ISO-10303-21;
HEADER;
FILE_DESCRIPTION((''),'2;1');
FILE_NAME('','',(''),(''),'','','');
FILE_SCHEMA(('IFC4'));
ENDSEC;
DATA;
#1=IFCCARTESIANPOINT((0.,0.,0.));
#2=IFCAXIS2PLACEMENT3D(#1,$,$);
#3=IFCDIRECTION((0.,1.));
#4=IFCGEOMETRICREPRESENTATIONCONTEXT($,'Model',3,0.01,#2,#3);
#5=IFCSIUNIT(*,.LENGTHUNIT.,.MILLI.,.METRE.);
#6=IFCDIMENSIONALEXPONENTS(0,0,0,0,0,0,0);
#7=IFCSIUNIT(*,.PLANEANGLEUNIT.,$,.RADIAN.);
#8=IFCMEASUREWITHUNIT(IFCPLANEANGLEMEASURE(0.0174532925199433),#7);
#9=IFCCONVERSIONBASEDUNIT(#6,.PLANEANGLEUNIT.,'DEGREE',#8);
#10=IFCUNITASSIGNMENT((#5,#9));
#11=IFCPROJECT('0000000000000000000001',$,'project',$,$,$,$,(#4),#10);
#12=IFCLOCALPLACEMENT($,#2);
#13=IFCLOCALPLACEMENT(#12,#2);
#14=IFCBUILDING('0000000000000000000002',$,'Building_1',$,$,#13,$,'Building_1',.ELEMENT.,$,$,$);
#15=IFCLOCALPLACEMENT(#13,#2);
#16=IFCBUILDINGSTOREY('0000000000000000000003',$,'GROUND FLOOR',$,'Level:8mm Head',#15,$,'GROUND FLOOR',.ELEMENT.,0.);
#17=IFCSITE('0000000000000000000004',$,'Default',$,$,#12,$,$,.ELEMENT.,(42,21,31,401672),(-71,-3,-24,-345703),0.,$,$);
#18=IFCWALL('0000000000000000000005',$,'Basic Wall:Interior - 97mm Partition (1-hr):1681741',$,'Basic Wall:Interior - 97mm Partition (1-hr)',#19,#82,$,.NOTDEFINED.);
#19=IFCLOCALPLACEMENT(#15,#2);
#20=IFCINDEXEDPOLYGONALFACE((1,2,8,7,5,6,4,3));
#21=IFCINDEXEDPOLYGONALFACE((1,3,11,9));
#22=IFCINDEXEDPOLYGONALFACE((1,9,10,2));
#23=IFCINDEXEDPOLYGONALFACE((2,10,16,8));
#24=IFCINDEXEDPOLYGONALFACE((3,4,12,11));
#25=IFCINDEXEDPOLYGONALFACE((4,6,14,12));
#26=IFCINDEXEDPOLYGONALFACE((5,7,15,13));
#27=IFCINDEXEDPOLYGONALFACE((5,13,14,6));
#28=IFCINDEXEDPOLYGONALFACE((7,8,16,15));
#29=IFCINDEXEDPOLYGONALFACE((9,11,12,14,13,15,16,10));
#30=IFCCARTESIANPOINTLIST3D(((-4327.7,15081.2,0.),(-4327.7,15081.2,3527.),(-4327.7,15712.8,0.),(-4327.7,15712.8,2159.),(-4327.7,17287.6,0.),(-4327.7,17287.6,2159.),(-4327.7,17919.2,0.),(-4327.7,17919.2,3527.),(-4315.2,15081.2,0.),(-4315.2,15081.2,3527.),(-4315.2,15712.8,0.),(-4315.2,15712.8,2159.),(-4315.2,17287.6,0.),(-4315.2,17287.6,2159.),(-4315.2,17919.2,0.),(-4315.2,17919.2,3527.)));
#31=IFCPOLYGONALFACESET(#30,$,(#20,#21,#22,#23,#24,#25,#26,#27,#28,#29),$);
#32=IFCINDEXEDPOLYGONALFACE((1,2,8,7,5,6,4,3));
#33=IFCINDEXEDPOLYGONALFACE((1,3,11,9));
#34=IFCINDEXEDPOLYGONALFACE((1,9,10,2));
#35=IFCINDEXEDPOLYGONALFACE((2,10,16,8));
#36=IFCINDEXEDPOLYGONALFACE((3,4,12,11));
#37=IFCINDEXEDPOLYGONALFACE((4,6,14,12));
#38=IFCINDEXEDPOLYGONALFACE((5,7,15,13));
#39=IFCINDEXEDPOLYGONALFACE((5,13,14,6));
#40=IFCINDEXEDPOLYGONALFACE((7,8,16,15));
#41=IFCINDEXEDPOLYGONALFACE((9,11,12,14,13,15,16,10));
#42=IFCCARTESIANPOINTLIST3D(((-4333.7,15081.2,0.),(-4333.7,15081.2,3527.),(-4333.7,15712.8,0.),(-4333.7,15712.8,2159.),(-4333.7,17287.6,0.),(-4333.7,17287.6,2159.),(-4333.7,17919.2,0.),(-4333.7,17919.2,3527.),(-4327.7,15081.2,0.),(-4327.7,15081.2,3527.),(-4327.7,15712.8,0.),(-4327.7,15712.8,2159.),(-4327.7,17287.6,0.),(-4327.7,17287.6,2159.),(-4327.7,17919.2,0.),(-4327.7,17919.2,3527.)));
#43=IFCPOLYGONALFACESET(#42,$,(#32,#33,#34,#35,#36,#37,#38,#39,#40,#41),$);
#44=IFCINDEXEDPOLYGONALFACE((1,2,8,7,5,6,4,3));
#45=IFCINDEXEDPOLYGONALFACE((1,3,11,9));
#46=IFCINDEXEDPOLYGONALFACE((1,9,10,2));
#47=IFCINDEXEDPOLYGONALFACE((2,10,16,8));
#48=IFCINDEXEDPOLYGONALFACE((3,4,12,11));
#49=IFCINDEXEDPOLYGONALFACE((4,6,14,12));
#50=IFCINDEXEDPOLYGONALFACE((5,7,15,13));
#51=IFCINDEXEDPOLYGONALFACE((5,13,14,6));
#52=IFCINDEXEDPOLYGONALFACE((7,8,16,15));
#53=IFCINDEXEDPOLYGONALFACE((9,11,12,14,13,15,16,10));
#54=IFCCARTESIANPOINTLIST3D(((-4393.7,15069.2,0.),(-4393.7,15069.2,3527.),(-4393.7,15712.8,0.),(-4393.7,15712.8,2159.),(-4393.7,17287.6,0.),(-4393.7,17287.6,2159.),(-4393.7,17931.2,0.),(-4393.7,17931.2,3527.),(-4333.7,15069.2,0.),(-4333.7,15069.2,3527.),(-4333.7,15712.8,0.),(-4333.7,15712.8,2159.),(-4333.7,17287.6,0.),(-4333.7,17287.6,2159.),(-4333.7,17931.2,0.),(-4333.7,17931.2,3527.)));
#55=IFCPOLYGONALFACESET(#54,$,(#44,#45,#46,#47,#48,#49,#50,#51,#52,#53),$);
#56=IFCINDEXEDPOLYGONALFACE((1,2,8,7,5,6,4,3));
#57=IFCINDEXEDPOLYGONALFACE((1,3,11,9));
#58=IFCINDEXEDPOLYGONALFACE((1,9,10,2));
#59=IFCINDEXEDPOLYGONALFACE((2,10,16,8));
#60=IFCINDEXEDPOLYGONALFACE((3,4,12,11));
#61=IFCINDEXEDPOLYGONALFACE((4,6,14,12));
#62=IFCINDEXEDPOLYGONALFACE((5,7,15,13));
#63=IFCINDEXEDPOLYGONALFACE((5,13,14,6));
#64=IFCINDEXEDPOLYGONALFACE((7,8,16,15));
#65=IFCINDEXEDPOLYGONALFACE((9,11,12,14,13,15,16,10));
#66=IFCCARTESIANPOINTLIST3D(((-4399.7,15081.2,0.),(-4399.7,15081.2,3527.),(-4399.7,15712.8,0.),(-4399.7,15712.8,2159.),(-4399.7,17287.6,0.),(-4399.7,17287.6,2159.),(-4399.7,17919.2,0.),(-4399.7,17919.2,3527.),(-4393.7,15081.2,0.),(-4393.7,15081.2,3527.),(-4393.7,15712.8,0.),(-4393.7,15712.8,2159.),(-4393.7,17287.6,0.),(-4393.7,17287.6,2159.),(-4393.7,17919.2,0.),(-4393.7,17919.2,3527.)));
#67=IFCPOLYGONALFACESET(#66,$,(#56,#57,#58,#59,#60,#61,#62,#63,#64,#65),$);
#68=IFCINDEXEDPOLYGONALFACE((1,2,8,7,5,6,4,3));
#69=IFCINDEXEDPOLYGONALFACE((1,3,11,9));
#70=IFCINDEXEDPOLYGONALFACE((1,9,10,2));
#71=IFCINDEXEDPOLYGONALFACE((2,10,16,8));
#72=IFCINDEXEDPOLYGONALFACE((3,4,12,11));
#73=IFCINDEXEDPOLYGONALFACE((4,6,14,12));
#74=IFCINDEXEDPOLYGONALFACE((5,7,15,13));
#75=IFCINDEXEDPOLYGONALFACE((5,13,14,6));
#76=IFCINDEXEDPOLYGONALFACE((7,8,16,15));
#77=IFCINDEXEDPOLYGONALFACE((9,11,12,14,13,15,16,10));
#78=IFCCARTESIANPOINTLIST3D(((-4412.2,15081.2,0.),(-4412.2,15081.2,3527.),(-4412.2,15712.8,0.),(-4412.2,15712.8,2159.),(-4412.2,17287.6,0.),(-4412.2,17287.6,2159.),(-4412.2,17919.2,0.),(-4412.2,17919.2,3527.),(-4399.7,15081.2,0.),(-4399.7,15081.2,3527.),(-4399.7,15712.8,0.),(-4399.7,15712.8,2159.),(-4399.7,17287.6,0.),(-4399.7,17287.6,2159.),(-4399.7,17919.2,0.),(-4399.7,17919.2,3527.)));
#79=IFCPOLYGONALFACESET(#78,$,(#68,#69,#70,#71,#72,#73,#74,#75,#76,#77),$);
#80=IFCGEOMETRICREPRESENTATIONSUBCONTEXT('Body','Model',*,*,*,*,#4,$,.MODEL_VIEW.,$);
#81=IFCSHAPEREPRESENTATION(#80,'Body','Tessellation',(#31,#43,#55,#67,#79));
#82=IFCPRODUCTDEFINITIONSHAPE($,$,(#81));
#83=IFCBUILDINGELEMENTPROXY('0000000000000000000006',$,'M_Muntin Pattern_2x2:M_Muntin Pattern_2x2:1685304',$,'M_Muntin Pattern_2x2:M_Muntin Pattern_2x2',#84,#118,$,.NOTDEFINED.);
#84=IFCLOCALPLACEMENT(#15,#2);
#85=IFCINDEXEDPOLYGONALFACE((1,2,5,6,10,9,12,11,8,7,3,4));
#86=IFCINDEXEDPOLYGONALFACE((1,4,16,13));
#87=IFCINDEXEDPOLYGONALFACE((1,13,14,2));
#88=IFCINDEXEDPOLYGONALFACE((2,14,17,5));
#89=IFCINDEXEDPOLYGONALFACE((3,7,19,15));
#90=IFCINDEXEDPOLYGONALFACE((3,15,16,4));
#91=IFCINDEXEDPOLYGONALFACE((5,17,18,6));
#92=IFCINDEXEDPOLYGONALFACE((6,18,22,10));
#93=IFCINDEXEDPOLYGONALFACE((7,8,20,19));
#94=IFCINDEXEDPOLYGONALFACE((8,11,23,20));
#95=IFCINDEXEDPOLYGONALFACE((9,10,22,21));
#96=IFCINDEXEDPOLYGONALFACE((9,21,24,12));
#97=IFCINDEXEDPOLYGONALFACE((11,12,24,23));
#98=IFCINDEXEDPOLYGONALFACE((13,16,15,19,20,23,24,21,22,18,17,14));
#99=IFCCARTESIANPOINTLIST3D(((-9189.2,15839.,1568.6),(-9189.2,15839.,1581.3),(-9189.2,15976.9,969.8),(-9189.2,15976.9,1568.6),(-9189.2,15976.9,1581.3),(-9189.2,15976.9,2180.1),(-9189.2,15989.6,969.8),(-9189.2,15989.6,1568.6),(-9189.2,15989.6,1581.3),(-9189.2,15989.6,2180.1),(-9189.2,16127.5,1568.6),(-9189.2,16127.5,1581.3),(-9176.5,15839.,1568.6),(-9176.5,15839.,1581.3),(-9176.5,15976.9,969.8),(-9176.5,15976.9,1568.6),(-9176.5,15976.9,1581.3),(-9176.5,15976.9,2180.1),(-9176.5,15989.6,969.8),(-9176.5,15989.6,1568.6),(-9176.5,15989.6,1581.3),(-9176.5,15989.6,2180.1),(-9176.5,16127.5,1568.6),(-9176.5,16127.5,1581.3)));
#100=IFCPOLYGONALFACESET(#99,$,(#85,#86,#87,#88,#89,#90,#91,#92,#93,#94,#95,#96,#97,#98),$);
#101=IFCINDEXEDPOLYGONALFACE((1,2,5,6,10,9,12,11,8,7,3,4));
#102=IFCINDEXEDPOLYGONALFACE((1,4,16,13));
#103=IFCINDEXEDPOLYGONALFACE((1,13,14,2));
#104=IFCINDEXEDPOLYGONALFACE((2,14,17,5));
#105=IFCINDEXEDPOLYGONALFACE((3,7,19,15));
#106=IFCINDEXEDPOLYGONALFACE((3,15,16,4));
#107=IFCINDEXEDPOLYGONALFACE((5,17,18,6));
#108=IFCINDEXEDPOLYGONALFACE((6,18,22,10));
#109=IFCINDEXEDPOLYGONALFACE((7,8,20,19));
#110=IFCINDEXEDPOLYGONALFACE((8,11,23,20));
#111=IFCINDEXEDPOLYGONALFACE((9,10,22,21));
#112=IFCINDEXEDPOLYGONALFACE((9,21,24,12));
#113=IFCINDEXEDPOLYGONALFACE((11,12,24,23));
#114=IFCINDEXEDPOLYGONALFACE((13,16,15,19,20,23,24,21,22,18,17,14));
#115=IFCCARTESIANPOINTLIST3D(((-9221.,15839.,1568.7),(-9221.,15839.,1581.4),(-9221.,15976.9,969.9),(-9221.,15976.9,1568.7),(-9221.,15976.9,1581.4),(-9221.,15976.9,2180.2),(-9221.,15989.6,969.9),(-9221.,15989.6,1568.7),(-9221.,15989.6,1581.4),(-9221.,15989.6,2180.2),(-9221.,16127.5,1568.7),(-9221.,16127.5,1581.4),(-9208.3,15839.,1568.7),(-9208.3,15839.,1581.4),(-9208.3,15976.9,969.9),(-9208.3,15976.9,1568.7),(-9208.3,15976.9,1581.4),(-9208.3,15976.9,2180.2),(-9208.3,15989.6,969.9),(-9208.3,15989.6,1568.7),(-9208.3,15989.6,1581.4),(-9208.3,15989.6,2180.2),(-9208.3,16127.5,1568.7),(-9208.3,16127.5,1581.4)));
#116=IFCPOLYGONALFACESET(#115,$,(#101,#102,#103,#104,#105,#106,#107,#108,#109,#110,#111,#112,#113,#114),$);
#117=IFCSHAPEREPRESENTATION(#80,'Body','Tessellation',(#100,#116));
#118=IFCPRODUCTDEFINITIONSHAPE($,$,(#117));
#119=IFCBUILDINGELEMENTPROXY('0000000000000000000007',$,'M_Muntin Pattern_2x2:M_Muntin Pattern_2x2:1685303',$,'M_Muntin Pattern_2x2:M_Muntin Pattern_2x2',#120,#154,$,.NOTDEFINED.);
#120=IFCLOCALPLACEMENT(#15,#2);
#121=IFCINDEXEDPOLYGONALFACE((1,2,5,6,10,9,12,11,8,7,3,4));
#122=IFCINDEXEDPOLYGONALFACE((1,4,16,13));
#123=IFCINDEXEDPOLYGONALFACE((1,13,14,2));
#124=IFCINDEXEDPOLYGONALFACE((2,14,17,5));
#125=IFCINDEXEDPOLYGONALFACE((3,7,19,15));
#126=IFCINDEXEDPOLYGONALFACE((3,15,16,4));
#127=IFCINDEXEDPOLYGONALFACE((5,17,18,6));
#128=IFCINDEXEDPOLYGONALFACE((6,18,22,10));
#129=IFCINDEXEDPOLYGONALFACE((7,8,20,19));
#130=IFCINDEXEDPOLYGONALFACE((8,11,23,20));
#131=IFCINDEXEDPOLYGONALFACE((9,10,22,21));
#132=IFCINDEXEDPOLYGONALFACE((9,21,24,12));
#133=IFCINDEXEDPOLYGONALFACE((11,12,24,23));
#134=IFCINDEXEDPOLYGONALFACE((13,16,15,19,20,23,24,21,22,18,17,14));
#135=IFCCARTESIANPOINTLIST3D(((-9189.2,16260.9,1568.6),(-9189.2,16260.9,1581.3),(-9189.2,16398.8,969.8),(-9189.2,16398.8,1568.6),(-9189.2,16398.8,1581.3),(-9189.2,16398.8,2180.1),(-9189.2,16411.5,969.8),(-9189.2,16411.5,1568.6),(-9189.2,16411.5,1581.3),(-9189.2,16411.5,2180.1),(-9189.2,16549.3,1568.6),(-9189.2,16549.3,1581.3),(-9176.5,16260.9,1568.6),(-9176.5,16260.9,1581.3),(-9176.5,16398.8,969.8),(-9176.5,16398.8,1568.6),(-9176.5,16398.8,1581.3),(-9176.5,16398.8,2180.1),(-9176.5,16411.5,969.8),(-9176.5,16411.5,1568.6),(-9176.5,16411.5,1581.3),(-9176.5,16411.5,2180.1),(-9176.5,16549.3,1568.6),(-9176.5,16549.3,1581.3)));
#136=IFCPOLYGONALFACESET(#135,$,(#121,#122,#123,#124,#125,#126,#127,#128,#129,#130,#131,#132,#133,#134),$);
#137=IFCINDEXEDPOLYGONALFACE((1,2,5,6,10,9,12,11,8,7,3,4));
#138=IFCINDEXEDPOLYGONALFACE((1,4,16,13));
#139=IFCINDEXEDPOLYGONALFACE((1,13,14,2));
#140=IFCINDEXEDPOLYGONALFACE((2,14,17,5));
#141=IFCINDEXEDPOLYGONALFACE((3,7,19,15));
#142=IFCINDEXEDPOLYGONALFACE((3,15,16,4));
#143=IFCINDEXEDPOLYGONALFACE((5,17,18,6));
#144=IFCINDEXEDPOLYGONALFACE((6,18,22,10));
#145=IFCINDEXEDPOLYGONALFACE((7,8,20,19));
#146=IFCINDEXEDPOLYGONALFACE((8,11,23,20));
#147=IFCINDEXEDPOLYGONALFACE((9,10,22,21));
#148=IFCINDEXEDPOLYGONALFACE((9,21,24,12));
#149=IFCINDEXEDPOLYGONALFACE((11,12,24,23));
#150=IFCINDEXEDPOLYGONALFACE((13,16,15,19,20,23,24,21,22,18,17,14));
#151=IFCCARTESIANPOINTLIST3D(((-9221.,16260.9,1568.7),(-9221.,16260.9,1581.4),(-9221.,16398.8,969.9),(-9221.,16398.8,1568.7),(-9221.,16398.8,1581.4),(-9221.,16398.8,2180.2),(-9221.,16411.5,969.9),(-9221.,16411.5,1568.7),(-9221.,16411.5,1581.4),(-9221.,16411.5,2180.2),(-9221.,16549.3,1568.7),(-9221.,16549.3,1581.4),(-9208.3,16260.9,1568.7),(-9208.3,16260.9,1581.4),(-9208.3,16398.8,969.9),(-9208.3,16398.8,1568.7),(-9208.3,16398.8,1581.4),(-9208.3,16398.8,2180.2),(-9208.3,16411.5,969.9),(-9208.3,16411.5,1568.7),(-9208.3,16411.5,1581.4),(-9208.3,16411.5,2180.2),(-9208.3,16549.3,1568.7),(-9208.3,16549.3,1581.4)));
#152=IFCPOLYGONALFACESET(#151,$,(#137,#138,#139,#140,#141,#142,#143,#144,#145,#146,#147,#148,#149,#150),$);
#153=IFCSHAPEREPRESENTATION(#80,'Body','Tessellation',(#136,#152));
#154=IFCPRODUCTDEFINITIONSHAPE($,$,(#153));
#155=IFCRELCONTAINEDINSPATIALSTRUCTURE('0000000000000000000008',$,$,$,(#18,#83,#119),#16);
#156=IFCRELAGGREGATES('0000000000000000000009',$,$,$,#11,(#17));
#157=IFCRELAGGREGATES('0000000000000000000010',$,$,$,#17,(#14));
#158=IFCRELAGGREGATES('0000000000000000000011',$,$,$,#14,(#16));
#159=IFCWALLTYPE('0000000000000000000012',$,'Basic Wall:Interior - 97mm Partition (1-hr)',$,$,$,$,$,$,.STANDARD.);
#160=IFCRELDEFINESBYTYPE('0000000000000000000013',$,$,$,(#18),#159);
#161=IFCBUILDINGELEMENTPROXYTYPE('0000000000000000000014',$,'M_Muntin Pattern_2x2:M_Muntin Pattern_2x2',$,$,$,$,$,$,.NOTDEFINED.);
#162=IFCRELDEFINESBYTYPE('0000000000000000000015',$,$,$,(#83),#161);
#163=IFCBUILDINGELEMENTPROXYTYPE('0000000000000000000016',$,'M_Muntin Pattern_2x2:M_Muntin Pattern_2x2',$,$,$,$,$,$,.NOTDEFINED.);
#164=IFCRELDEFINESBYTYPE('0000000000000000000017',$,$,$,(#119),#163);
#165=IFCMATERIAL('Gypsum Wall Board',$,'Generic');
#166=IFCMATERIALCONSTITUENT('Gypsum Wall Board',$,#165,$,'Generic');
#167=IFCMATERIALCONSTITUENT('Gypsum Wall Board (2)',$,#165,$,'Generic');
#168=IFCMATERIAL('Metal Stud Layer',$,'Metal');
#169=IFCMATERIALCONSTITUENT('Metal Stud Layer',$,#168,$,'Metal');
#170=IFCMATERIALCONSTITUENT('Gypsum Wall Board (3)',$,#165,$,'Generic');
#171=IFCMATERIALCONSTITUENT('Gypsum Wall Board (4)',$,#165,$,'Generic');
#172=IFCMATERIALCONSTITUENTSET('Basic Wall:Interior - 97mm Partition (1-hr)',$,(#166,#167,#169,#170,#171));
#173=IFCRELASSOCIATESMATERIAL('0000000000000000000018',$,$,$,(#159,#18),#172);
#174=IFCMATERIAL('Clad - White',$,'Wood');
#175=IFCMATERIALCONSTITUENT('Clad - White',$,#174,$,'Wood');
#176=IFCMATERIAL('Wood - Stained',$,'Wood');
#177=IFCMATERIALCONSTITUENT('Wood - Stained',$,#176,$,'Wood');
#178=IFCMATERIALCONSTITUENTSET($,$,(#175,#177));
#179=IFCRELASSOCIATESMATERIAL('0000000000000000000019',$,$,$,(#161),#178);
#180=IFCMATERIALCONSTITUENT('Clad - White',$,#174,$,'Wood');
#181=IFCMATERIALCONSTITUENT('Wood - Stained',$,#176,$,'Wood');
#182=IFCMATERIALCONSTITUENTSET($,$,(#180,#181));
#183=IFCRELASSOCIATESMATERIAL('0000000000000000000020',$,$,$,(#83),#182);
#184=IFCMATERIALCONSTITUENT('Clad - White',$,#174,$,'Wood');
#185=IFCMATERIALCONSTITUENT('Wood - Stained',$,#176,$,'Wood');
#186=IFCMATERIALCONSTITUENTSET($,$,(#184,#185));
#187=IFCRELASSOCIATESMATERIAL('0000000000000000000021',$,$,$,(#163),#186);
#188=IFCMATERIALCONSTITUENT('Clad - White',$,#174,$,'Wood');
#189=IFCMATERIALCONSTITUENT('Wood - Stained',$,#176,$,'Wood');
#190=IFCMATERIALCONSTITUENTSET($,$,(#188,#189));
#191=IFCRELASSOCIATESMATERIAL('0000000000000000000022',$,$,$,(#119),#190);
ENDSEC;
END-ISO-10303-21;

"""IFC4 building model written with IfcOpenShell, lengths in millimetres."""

from ifc_helpers import new_model, entity, si_unit, converted_unit, direction, frame, origin, place, context, subcontext, project, spatial, indexed_curve, outline, extrude, source, transform, mapped, material, constituent, constituent_set, type_object, type_shapes, element, save


model = new_model("IFC4")

# Units and contexts
model_context = context("Model", 3, precision=0.01, world=origin(), true_north=direction((0.0, 1.0)))
body_context = subcontext(model_context, "Body", "Model", "MODEL_VIEW")
ifc_project = project(units=[si_unit("LENGTHUNIT", "METRE", prefix="MILLI"), converted_unit("PLANEANGLEUNIT", "DEGREE", entity("IfcPlaneAngleMeasure", 0.0174532925199433), si_unit("PLANEANGLEUNIT", "RADIAN"), dimensions=[0, 0, 0, 0, 0, 0, 0])], contexts=[model_context])

# Site, building, storey
site_placement = place(None, origin())
site = spatial("IfcSite", under=ifc_project, at=site_placement, Name="Default", CompositionType="ELEMENT", RefLatitude=(42, 21, 31, 401672), RefLongitude=(-71, -3, -24, -345703), RefElevation=0.0)
building_placement = place(site_placement, origin())
building = spatial("IfcBuilding", under=site, at=building_placement, Name="Building_1", LongName="Building_1", CompositionType="ELEMENT")
storey_placement = place(building_placement, origin())
storey = spatial("IfcBuildingStorey", under=building, at=storey_placement, Name="GROUND FLOOR", ObjectType="Level:8mm Head", LongName="GROUND FLOOR", CompositionType="ELEMENT", Elevation=0.0)

# Shared definitions
ifc_material_1 = material(Name="Wood - Stained", Category="Wood")

# Wall, opening
ifc_material_2 = material(Name="Gypsum Wall Board", Category="Generic")
ifc_constituent_1 = constituent(ifc_material_2, Name="Gypsum Wall Board", Category="Generic")
ifc_constituent_2 = constituent(ifc_material_2, Name="Gypsum Wall Board (2)", Category="Generic")
ifc_material_3 = material(Name="Metal Stud Layer", Category="Metal")
ifc_constituent_3 = constituent(ifc_material_3, Name="Metal Stud Layer", Category="Metal")
ifc_constituent_4 = constituent(ifc_material_2, Name="Gypsum Wall Board (3)", Category="Generic")
ifc_constituent_5 = constituent(ifc_material_2, Name="Gypsum Wall Board (4)", Category="Generic")
ifc_constituent_set_1 = constituent_set(constituents=[ifc_constituent_1, ifc_constituent_2, ifc_constituent_3, ifc_constituent_4, ifc_constituent_5], Name="Basic Wall:Interior - 97mm Partition (1-hr)")
wall_type_1 = type_object("IfcWallType", Name="Basic Wall:Interior - 97mm Partition (1-hr)", PredefinedType="STANDARD", material=ifc_constituent_set_1)
wall_1_placement = place(storey_placement, frame((-4363.7, 15081.2, 0.0), z_axis=(0.0, 0.0, 1.0), x_axis=(0.0, 1.0, 0.0)))
wall_1 = element("IfcWall", 1, at=wall_1_placement, inside=storey, type_object=wall_type_1, material=ifc_constituent_set_1, Name="Basic Wall:Interior - 97mm Partition (1-hr):1681741", ObjectType="Basic Wall:Interior - 97mm Partition (1-hr)", PredefinedType="NOTDEFINED", context=body_context, shape_type="SweptSolid", body=[
    extrude(outline(indexed_curve([(-1421.5, -1419.0), (2105.5, -1419.0), (2105.5, 1419.0), (-1421.5, 1419.0), (-1421.5, 787.4), (737.5, 787.4), (737.5, -787.4), (-1421.5, -787.4), (-1421.5, -1419.0)], self_intersect=False)), frame((1419.0, -36.0, 1421.5), z_axis=(0.0, -1.0, 0.0), x_axis=(0.0, 0.0, 1.0)), (0.0, 0.0, 1.0), 12.5),
    extrude(outline(indexed_curve([(-1421.5, -1419.0), (2105.5, -1419.0), (2105.5, 1419.0), (-1421.5, 1419.0), (-1421.5, 787.4), (737.5, 787.4), (737.5, -787.4), (-1421.5, -787.4), (-1421.5, -1419.0)], self_intersect=False)), frame((1419.0, -30.0, 1421.5), z_axis=(0.0, -1.0, 0.0), x_axis=(0.0, 0.0, 1.0)), (0.0, 0.0, 1.0), 6.0),
    extrude(outline(indexed_curve([(-1421.5, -1431.0), (2105.5, -1431.0), (2105.5, 1431.0), (-1421.5, 1431.0), (-1421.5, 787.4), (737.5, 787.4), (737.5, -787.4), (-1421.5, -787.4), (-1421.5, -1431.0)], self_intersect=False)), frame((1419.0, 30.0, 1421.5), z_axis=(0.0, -1.0, 0.0), x_axis=(0.0, 0.0, 1.0)), (0.0, 0.0, 1.0), 60.0),
    extrude(outline(indexed_curve([(-1421.5, -1419.0), (2105.5, -1419.0), (2105.5, 1419.0), (-1421.5, 1419.0), (-1421.5, 787.4), (737.5, 787.4), (737.5, -787.4), (-1421.5, -787.4), (-1421.5, -1419.0)], self_intersect=False)), frame((1419.0, 36.0, 1421.5), z_axis=(0.0, -1.0, 0.0), x_axis=(0.0, 0.0, 1.0)), (0.0, 0.0, 1.0), 6.0),
    extrude(outline(indexed_curve([(-1419.0, -2105.5), (1419.0, -2105.5), (1419.0, 1421.5), (787.4, 1421.5), (787.4, -737.5), (-787.4, -737.5), (-787.4, 1421.5), (-1419.0, 1421.5), (-1419.0, -2105.5)], self_intersect=False)), frame((1419.0, 48.5, 1421.5), z_axis=(0.0, -1.0, 0.0), x_axis=(-1.0, 0.0, 0.0)), (0.0, 0.0, 1.0), 12.5),
])
opening_1_placement = place(wall_1_placement, frame((2206.4, 48.5, 0.0)))
element("IfcOpeningElement", 2, at=opening_1_placement, cuts=wall_1, PredefinedType="OPENING", context=body_context, shape_type="SweptSolid", body=[
    extrude(outline(indexed_curve([(0.0, 1574.8), (0.0, 0.0), (2159.0, 0.0), (2159.0, 1574.8), (0.0, 1574.8)], self_intersect=False)), frame((0.0, 0.0, 0.0), z_axis=(0.0, -1.0, 0.0), x_axis=(0.0, 0.0, 1.0)), (0.0, 0.0, 1.0), 97.0),
])

# Building element proxies
ifc_material_4 = material(Name="Clad - White", Category="Wood")
ifc_constituent_6 = constituent(ifc_material_4, Name="Clad - White", Category="Wood")
ifc_constituent_7 = constituent(ifc_material_1, Name="Wood - Stained", Category="Wood")
ifc_constituent_set_2 = constituent_set(constituents=[ifc_constituent_6, ifc_constituent_7])
ifc_constituent_8 = constituent(ifc_material_4, Name="Clad - White", Category="Wood")
ifc_constituent_9 = constituent(ifc_material_1, Name="Wood - Stained", Category="Wood")
ifc_constituent_set_3 = constituent_set(constituents=[ifc_constituent_8, ifc_constituent_9])
building_element_proxy_type_1 = type_object("IfcBuildingElementProxyType", Name="M_Muntin Pattern_2x2:M_Muntin Pattern_2x2", PredefinedType="NOTDEFINED", material=ifc_constituent_set_3)
shared_shape_1 = source(origin(), body_context, "Body", "SweptSolid", [
    extrude(outline(indexed_curve([(6.4, -6.4), (605.1, -6.4), (605.1, 6.3), (6.4, 6.3), (6.4, 144.2), (-6.3, 144.2), (-6.3, 6.3), (-605.2, 6.3), (-605.2, -6.4), (-6.3, -6.4), (-6.3, -144.2), (6.4, -144.2), (6.4, -6.4)], self_intersect=False)), frame((0.0, -22.2, 605.1), z_axis=(0.0, 1.0, 0.0), x_axis=(0.0, 0.0, 1.0)), (0.0, 0.0, 1.0), 12.7),
    extrude(outline(indexed_curve([(6.4, -6.4), (605.2, -6.4), (605.2, 6.3), (6.4, 6.3), (6.4, 144.2), (-6.3, 144.2), (-6.3, 6.3), (-605.2, 6.3), (-605.2, -6.4), (-6.3, -6.4), (-6.3, -144.2), (6.4, -144.2), (6.4, -6.4)], self_intersect=False)), frame((0.0, 9.5, 605.2), z_axis=(0.0, 1.0, 0.0), x_axis=(0.0, 0.0, 1.0)), (0.0, 0.0, 1.0), 12.7),
])
type_shapes(building_element_proxy_type_1, [shared_shape_1])
proxy_1_placement = place(storey_placement, frame((-9198.7, 15983.3, 969.9), z_axis=(0.0, 0.0, 1.0), x_axis=(0.0, 1.0, 0.0)))
element("IfcBuildingElementProxy", 3, at=proxy_1_placement, inside=storey, type_object=building_element_proxy_type_1, material=ifc_constituent_set_2, Name="M_Muntin Pattern_2x2:M_Muntin Pattern_2x2:1685304", ObjectType="M_Muntin Pattern_2x2:M_Muntin Pattern_2x2", PredefinedType="NOTDEFINED", context=body_context, shape_type="MappedRepresentation", body=[
    mapped(shared_shape_1, transform((0.0, 0.0, 0.0), scale=1.0)),
])
ifc_constituent_10 = constituent(ifc_material_4, Name="Clad - White", Category="Wood")
ifc_constituent_11 = constituent(ifc_material_1, Name="Wood - Stained", Category="Wood")
ifc_constituent_set_4 = constituent_set(constituents=[ifc_constituent_10, ifc_constituent_11])
ifc_constituent_12 = constituent(ifc_material_4, Name="Clad - White", Category="Wood")
ifc_constituent_13 = constituent(ifc_material_1, Name="Wood - Stained", Category="Wood")
ifc_constituent_set_5 = constituent_set(constituents=[ifc_constituent_12, ifc_constituent_13])
building_element_proxy_type_2 = type_object("IfcBuildingElementProxyType", Name="M_Muntin Pattern_2x2:M_Muntin Pattern_2x2", PredefinedType="NOTDEFINED", material=ifc_constituent_set_5)
shared_shape_2 = source(origin(), body_context, "Body", "SweptSolid", [
    extrude(outline(indexed_curve([(6.4, -6.4), (605.1, -6.4), (605.1, 6.3), (6.4, 6.3), (6.4, 144.2), (-6.3, 144.2), (-6.3, 6.3), (-605.2, 6.3), (-605.2, -6.4), (-6.3, -6.4), (-6.3, -144.2), (6.4, -144.2), (6.4, -6.4)], self_intersect=False)), frame((0.0, 9.5, 605.1), z_axis=(0.0, 1.0, 0.0), x_axis=(0.0, 0.0, 1.0)), (0.0, 0.0, 1.0), 12.7),
    extrude(outline(indexed_curve([(6.4, -6.4), (605.2, -6.4), (605.2, 6.3), (6.4, 6.3), (6.4, 144.2), (-6.3, 144.2), (-6.3, 6.3), (-605.2, 6.3), (-605.2, -6.4), (-6.3, -6.4), (-6.3, -144.2), (6.4, -144.2), (6.4, -6.4)], self_intersect=False)), frame((0.0, -22.2, 605.2), z_axis=(0.0, 1.0, 0.0), x_axis=(0.0, 0.0, 1.0)), (0.0, 0.0, 1.0), 12.7),
])
type_shapes(building_element_proxy_type_2, [shared_shape_2])
proxy_2_placement = place(storey_placement, frame((-9198.7, 16405.1, 969.9), z_axis=(0.0, 0.0, 1.0), x_axis=(0.0, -1.0, 0.0)))
element("IfcBuildingElementProxy", 4, at=proxy_2_placement, inside=storey, type_object=building_element_proxy_type_2, material=ifc_constituent_set_4, Name="M_Muntin Pattern_2x2:M_Muntin Pattern_2x2:1685303", ObjectType="M_Muntin Pattern_2x2:M_Muntin Pattern_2x2", PredefinedType="NOTDEFINED", context=body_context, shape_type="MappedRepresentation", body=[
    mapped(shared_shape_2, transform((0.0, 0.0, 0.0), scale=1.0)),
])

save(model, "model.ifc")
